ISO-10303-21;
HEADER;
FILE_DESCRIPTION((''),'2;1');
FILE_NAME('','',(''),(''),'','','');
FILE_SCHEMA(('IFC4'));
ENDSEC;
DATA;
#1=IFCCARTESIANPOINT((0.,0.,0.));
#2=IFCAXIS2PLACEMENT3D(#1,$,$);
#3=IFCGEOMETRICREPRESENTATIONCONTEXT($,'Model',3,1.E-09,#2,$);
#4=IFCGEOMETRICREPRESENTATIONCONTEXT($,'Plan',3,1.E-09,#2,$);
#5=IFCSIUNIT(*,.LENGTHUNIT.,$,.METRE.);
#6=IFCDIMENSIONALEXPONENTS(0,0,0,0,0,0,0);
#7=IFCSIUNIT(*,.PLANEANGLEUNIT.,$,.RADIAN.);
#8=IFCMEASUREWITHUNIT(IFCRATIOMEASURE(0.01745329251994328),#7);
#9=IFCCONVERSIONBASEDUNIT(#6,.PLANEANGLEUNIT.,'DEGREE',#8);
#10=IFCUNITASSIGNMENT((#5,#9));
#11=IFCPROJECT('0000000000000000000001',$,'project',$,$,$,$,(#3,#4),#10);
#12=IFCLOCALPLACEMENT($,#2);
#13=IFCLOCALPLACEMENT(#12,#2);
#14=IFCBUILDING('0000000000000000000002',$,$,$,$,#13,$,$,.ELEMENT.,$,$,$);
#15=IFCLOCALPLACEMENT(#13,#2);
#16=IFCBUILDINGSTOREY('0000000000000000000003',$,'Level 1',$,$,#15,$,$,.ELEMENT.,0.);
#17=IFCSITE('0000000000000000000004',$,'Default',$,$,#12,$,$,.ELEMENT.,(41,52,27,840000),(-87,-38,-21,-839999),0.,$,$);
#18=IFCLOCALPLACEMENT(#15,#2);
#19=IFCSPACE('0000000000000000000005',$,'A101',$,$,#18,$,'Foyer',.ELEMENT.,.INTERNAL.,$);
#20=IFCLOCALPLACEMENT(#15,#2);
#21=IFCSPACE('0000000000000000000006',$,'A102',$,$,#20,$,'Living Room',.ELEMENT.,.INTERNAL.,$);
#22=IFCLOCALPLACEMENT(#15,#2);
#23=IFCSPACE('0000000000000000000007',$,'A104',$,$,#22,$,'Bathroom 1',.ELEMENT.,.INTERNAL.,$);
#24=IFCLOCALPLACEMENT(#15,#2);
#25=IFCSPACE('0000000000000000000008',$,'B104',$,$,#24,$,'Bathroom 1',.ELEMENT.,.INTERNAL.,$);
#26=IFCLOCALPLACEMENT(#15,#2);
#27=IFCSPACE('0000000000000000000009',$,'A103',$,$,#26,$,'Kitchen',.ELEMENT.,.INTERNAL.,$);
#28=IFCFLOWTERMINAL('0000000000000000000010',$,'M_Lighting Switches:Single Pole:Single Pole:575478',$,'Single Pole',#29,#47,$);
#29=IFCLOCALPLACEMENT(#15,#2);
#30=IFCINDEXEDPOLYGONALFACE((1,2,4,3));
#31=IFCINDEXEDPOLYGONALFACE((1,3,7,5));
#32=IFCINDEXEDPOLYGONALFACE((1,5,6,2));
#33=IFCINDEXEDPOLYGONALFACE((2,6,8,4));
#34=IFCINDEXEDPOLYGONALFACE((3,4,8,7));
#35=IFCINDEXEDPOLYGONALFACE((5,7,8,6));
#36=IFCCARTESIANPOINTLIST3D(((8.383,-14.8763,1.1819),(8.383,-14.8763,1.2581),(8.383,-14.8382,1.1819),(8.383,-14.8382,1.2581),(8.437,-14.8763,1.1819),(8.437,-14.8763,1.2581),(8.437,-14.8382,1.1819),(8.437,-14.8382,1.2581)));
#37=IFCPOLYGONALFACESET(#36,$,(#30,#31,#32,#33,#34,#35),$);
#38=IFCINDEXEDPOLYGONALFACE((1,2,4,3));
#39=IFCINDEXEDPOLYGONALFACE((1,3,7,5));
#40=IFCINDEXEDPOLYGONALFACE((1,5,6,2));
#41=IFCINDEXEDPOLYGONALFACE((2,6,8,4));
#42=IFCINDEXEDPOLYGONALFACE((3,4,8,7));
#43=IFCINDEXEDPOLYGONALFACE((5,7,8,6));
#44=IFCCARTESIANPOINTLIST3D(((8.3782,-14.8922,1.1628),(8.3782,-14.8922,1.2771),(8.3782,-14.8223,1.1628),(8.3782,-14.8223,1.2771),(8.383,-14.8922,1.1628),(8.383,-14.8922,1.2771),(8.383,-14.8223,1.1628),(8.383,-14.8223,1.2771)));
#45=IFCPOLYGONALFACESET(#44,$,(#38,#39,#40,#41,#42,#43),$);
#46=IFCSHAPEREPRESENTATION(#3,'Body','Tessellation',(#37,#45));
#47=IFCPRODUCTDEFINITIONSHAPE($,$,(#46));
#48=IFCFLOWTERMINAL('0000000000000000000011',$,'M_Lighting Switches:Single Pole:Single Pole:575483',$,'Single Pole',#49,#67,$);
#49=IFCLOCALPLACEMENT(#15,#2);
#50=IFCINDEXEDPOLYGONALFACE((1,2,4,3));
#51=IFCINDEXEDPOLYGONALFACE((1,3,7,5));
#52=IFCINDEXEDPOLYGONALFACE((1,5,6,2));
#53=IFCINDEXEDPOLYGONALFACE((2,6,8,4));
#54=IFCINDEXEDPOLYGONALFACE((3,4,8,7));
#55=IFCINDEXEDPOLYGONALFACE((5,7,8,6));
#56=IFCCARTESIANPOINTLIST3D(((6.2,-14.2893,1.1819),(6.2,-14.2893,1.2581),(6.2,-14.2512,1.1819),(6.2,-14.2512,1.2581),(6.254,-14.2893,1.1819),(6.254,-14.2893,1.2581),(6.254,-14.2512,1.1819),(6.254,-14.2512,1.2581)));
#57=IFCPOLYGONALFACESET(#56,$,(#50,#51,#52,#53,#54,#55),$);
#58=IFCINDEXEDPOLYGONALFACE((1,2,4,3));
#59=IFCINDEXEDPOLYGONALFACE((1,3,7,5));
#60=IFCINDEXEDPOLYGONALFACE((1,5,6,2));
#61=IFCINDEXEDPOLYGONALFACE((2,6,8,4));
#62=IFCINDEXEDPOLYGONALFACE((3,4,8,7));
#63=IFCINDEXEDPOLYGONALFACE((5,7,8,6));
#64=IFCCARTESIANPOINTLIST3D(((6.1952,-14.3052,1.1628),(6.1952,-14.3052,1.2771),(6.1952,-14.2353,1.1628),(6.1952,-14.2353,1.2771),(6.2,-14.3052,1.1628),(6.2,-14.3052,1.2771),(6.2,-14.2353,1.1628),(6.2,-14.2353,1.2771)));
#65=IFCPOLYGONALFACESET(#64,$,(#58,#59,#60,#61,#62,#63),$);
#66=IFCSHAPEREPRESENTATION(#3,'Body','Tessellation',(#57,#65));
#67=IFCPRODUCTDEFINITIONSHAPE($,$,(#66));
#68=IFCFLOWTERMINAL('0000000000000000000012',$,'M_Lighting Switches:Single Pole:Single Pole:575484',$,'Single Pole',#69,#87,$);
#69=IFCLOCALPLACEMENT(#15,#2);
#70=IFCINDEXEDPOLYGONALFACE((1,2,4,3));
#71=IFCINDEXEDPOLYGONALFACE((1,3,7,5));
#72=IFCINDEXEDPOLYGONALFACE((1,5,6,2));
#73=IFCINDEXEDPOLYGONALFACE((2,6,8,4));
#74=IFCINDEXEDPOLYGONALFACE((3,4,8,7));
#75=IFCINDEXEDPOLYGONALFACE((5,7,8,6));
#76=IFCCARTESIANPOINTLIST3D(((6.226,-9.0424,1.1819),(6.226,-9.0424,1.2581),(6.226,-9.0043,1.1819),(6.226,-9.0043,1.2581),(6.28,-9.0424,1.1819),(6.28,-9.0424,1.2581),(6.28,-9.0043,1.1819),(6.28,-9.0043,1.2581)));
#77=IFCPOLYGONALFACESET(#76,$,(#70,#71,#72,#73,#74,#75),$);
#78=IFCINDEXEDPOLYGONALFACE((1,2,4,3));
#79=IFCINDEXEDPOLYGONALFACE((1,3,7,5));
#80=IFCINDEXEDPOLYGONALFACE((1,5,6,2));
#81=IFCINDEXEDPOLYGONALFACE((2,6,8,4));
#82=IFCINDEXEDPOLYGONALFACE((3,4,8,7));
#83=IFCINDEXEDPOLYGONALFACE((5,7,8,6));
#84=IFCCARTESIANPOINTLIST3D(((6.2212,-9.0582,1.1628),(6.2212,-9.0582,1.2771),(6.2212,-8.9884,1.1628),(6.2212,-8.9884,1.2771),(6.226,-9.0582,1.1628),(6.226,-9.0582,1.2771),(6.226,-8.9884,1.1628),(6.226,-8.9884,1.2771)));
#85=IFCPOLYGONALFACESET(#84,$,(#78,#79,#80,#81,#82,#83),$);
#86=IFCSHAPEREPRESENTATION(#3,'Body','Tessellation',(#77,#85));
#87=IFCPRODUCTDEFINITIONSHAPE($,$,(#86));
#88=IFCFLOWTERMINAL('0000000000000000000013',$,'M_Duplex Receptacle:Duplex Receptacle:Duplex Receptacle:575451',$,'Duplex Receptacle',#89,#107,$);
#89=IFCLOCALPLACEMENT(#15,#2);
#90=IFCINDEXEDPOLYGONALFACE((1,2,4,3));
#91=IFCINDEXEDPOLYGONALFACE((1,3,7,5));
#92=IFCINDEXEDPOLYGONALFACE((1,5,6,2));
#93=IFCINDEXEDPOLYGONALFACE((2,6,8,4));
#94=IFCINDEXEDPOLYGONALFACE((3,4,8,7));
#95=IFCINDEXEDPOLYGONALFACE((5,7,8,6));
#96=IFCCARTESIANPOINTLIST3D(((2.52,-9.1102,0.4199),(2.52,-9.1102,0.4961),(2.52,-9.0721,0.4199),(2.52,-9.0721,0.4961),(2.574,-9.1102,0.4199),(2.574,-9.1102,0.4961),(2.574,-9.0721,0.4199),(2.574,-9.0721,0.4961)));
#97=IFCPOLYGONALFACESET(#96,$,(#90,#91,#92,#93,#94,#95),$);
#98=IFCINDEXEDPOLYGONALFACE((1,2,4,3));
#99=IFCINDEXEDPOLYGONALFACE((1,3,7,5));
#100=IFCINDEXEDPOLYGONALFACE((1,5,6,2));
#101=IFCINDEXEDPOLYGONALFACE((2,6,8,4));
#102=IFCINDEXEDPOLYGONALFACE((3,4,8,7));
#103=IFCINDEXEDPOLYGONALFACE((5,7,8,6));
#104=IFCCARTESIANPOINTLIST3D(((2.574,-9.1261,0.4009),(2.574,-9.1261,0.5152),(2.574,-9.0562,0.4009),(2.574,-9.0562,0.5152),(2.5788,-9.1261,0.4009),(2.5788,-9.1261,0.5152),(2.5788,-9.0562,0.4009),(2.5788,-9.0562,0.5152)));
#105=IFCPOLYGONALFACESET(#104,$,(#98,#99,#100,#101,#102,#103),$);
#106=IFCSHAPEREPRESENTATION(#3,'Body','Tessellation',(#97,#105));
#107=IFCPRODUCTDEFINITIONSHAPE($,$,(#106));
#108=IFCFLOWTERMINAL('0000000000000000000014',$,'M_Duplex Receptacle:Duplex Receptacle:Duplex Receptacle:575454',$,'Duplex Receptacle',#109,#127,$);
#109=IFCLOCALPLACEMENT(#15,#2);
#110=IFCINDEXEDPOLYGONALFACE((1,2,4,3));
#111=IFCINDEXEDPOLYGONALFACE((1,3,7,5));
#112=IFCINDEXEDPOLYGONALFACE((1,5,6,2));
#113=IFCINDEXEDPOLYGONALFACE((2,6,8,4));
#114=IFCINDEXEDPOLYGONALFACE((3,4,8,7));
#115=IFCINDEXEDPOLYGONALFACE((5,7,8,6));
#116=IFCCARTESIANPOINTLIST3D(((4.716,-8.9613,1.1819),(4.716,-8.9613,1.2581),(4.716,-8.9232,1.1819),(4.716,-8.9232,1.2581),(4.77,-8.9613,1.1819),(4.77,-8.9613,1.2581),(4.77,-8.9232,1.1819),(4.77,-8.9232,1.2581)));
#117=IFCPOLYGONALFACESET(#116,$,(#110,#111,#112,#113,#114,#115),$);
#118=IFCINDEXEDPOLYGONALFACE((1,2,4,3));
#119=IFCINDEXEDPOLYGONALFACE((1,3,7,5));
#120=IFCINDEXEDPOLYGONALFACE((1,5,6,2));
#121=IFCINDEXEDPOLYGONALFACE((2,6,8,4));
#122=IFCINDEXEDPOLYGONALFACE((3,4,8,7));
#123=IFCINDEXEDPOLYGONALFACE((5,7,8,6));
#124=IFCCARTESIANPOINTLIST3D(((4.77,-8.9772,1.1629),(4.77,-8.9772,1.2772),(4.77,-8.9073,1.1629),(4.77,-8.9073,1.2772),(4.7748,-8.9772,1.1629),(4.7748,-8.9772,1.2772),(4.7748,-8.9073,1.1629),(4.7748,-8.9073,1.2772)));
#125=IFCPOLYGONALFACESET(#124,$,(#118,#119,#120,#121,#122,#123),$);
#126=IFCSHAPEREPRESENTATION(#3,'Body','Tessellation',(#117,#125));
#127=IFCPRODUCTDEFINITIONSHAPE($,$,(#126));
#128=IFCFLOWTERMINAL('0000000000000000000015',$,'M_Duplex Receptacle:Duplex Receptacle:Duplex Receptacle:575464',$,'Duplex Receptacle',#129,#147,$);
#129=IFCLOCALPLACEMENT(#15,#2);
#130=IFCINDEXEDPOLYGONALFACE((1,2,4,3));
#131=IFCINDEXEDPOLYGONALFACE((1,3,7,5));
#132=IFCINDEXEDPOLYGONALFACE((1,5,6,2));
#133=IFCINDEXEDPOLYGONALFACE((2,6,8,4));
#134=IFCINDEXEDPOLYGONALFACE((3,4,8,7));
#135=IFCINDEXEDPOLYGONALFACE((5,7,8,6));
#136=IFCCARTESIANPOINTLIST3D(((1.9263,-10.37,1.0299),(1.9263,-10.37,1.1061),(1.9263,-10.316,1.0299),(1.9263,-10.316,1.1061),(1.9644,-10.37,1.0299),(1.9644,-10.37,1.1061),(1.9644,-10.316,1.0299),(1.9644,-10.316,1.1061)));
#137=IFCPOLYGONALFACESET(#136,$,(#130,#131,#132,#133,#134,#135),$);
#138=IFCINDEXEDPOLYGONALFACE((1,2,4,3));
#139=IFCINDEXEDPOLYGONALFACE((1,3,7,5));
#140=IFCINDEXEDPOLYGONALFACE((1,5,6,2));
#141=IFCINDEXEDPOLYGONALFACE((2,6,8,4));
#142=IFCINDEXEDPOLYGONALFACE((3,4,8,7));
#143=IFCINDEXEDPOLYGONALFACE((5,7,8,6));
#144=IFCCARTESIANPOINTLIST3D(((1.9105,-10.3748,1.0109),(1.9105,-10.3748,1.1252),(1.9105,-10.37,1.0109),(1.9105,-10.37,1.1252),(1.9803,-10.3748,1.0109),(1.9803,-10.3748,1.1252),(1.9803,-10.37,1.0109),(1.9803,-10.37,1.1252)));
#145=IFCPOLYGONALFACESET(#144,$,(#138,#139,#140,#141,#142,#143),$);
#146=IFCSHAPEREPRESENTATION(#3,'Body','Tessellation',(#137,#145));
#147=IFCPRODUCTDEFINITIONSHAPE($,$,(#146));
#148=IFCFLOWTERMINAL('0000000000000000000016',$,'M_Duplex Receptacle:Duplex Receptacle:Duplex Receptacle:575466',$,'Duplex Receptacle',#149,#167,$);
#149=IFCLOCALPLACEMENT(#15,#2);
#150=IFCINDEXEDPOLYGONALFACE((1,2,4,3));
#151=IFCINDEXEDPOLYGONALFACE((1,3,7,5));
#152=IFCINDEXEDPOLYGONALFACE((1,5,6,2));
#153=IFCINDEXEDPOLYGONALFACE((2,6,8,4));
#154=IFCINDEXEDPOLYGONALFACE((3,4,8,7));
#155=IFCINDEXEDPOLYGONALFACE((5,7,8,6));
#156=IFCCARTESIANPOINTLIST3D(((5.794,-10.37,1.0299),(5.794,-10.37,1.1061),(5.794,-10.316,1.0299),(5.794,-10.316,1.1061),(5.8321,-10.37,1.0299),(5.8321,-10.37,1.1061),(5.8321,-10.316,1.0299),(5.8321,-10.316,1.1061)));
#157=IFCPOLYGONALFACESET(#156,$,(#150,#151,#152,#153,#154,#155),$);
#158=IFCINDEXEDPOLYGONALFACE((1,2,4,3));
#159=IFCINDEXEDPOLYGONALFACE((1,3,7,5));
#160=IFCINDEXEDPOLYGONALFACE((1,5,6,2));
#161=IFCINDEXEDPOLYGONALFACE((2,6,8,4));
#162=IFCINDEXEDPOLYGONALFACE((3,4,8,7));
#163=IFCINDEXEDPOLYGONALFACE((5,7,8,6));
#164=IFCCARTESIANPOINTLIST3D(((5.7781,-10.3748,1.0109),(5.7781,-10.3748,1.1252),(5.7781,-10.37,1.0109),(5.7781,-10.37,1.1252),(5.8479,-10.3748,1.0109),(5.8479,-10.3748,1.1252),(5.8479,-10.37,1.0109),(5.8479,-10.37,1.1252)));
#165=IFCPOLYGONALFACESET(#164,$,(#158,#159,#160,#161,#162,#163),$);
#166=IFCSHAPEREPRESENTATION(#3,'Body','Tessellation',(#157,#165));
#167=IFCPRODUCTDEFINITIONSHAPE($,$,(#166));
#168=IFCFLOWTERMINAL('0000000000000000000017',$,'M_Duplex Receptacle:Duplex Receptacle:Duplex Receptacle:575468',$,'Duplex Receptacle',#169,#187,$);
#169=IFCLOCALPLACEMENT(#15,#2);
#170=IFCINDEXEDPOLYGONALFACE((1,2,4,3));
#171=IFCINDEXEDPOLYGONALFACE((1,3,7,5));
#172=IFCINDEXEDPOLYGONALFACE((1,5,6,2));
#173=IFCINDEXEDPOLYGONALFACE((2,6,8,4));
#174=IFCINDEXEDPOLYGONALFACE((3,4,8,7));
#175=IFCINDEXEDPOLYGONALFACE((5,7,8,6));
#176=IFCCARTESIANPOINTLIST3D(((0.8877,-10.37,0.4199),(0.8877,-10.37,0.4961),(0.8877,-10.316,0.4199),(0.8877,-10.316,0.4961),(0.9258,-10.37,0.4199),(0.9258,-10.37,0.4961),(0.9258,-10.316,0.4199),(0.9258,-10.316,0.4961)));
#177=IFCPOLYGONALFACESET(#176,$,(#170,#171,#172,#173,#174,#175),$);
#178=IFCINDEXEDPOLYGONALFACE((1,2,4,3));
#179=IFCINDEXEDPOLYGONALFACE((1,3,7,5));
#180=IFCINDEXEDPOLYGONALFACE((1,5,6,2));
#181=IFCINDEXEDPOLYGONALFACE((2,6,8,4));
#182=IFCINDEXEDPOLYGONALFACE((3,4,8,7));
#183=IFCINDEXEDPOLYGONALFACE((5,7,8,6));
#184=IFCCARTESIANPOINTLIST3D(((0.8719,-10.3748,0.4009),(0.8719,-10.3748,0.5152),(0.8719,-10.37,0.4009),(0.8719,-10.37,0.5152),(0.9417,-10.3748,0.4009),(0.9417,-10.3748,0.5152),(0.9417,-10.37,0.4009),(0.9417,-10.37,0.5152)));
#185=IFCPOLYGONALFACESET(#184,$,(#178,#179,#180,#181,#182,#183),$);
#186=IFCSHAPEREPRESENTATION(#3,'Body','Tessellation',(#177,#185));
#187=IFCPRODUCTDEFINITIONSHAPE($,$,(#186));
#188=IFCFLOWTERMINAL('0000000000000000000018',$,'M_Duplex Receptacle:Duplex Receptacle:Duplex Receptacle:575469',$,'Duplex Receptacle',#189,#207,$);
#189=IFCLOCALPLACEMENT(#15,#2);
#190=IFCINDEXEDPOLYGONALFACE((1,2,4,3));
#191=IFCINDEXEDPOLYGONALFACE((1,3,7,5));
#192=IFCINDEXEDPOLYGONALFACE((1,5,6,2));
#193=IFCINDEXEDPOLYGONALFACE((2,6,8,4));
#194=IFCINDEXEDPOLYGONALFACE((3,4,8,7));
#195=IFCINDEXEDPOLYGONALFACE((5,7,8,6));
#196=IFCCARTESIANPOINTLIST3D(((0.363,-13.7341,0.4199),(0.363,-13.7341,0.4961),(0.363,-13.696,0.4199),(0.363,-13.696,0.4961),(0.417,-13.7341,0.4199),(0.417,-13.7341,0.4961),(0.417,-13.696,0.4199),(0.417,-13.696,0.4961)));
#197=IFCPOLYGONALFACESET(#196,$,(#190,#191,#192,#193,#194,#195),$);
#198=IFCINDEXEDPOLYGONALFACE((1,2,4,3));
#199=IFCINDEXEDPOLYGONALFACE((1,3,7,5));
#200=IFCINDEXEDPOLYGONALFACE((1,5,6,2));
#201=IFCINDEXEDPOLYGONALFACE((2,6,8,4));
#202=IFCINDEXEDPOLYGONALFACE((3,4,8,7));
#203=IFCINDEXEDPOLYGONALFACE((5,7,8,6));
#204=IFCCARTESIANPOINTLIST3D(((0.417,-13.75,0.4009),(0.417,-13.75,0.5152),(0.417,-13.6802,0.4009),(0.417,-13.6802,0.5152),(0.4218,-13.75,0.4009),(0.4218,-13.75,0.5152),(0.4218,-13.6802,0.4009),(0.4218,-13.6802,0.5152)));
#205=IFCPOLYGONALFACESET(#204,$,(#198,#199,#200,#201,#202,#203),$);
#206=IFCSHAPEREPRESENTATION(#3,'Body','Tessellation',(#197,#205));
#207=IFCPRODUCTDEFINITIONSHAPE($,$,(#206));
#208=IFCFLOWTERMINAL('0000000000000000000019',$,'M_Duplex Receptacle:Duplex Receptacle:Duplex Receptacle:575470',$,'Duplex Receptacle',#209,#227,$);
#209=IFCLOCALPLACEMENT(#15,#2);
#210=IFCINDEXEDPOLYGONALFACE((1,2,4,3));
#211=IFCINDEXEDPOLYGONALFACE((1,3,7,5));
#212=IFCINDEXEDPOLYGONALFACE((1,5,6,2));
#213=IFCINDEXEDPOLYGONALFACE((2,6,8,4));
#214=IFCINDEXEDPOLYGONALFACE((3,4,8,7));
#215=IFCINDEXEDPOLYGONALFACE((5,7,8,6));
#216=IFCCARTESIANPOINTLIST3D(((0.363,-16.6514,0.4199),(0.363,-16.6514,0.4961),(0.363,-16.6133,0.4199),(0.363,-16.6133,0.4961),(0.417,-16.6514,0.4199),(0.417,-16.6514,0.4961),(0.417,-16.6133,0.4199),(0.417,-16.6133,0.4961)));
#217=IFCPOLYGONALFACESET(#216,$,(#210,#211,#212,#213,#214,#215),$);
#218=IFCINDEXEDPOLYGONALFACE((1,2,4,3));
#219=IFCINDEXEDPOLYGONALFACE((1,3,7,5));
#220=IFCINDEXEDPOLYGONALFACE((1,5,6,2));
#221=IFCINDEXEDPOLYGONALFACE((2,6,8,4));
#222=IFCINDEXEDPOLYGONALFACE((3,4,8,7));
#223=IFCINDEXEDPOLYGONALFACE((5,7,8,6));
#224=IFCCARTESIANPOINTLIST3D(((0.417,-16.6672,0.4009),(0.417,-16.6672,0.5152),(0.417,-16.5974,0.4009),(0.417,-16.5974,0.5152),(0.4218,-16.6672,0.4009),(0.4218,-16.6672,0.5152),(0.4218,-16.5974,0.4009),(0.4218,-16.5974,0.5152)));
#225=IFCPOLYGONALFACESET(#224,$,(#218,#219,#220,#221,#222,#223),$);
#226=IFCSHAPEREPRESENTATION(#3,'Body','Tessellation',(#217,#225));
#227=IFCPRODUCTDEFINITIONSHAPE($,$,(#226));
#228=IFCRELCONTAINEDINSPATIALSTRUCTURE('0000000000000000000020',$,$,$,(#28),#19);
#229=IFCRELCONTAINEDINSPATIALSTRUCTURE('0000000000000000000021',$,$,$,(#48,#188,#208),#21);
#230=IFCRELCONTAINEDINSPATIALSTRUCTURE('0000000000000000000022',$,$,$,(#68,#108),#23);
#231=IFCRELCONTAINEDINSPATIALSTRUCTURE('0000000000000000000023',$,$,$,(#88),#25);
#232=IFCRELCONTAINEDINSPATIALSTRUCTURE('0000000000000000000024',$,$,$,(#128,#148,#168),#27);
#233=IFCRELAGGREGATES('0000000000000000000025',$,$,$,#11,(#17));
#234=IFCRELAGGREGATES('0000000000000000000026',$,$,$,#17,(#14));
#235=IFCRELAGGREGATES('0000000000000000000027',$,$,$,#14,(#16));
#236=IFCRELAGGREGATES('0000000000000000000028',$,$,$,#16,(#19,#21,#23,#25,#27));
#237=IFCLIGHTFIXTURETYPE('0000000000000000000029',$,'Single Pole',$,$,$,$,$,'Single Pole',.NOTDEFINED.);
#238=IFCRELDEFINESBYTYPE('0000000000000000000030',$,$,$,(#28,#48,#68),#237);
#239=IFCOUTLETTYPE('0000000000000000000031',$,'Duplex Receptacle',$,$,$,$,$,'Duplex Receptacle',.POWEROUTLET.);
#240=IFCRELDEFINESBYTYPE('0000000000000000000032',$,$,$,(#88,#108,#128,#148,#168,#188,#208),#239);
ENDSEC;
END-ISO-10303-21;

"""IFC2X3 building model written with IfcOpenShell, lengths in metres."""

from ifc_helpers import new_model, entity, si_unit, converted_unit, frame, origin, origin_2d_with_axis, place, context, project, spatial, rectangle, extrude, source, transform, mapped, type_object, type_shapes, element, save


model = new_model("IFC2X3")

# Units and contexts
model_context = context("Model", 3, precision=1e-09, world=origin())
plan_context = context("Plan", 3, precision=1e-09, world=origin())
ifc_project = project(units=[si_unit("LENGTHUNIT", "METRE"), converted_unit("PLANEANGLEUNIT", "DEGREE", entity("IfcRatioMeasure", 0.01745329251994328), si_unit("PLANEANGLEUNIT", "RADIAN"), dimensions=[0, 0, 0, 0, 0, 0, 0])], contexts=[model_context, plan_context])

# Site, building, storey, space
site_placement = place(None, origin())
site = spatial("IfcSite", under=ifc_project, at=site_placement, Name="Default", CompositionType="ELEMENT", RefLatitude=(41, 52, 27, 840000), RefLongitude=(-87, -38, -21, -839999), RefElevation=0.0)
building_placement = place(site_placement, origin())
building = spatial("IfcBuilding", under=site, at=building_placement, CompositionType="ELEMENT")
storey_placement = place(building_placement, origin())
storey = spatial("IfcBuildingStorey", under=building, at=storey_placement, Name="Level 1", CompositionType="ELEMENT", Elevation=0.0)
space_1_placement = place(storey_placement, origin())
space_1 = spatial("IfcSpace", under=storey, at=space_1_placement, Name="A101", LongName="Foyer", CompositionType="ELEMENT", InteriorOrExteriorSpace="INTERNAL")

# Flow terminal
light_fixture_type = type_object("IfcLightFixtureType", Name="Single Pole", ElementType="Single Pole", PredefinedType="NOTDEFINED")
shared_shape_1 = source(origin(), model_context, "Body", "SweptSolid", [
    extrude(rectangle(XDim=0.0381, YDim=0.0762, at=origin_2d_with_axis()), frame((0.0, 0.0, -0.054), z_axis=(0.0, 0.0, 1.0), x_axis=(-1.0, 0.0, 0.0)), (0.0, 0.0, 1.0), 0.054),
    extrude(rectangle(XDim=0.0698, YDim=0.1143, at=origin_2d_with_axis()), frame((0.0, 0.0, 0.0), z_axis=(0.0, 0.0, 1.0), x_axis=(-1.0, 0.0, 0.0)), (0.0, 0.0, 1.0), 0.0048),
])
type_shapes(light_fixture_type, [shared_shape_1])
flow_terminal_1_placement = place(space_1_placement, frame((8.383, -14.8573, 1.22), z_axis=(-1.0, 0.0, 0.0), x_axis=(0.0, -1.0, 0.0)))
element("IfcFlowTerminal", 1, at=flow_terminal_1_placement, inside=space_1, type_object=light_fixture_type, Name="M_Lighting Switches:Single Pole:Single Pole:575478", ObjectType="Single Pole", context=model_context, shape_type="MappedRepresentation", body=[
    mapped(shared_shape_1, transform((0.0, 0.0, 0.0), scale=1.0)),
])

# Shared definitions
space_2_placement = place(storey_placement, origin())
space_2 = spatial("IfcSpace", under=storey, at=space_2_placement, Name="A102", LongName="Living Room", CompositionType="ELEMENT", InteriorOrExteriorSpace="INTERNAL")

# Flow terminal
flow_terminal_2_placement = place(space_2_placement, frame((6.2, -14.2702, 1.22), z_axis=(-1.0, 0.0, 0.0), x_axis=(0.0, -1.0, 0.0)))
element("IfcFlowTerminal", 2, at=flow_terminal_2_placement, inside=space_2, type_object=light_fixture_type, Name="M_Lighting Switches:Single Pole:Single Pole:575483", ObjectType="Single Pole", context=model_context, shape_type="MappedRepresentation", body=[
    mapped(shared_shape_1, transform((0.0, 0.0, 0.0), scale=1.0)),
])

# Shared definitions
space_3_placement = place(storey_placement, origin())
space_3 = spatial("IfcSpace", under=storey, at=space_3_placement, Name="A104", LongName="Bathroom 1", CompositionType="ELEMENT", InteriorOrExteriorSpace="INTERNAL")

# Flow terminal
flow_terminal_3_placement = place(space_3_placement, frame((6.226, -9.0233, 1.22), z_axis=(-1.0, 0.0, 0.0), x_axis=(0.0, -1.0, 0.0)))
element("IfcFlowTerminal", 3, at=flow_terminal_3_placement, inside=space_3, type_object=light_fixture_type, Name="M_Lighting Switches:Single Pole:Single Pole:575484", ObjectType="Single Pole", context=model_context, shape_type="MappedRepresentation", body=[
    mapped(shared_shape_1, transform((0.0, 0.0, 0.0), scale=1.0)),
])

# Shared definitions
space_4_placement = place(storey_placement, origin())
space_4 = spatial("IfcSpace", under=storey, at=space_4_placement, Name="B104", LongName="Bathroom 1", CompositionType="ELEMENT", InteriorOrExteriorSpace="INTERNAL")

# Flow terminals
outlet_type = type_object("IfcOutletType", Name="Duplex Receptacle", ElementType="Duplex Receptacle", PredefinedType="POWEROUTLET")
shared_shape_2 = source(origin(), model_context, "Body", "SweptSolid", [
    extrude(rectangle(XDim=0.0381, YDim=0.0762, at=origin_2d_with_axis()), frame((0.0, 0.0, -0.054), z_axis=(0.0, 0.0, 1.0), x_axis=(-1.0, 0.0, 0.0)), (0.0, 0.0, 1.0), 0.054),
    extrude(rectangle(XDim=0.0698, YDim=0.1143, at=origin_2d_with_axis()), frame((0.0, 0.0, 0.0), z_axis=(0.0, 0.0, 1.0), x_axis=(-1.0, 0.0, 0.0)), (0.0, 0.0, 1.0), 0.0048),
])
type_shapes(outlet_type, [shared_shape_2])
flow_terminal_4_placement = place(space_4_placement, frame((2.574, -9.0912, 0.458), z_axis=(1.0, 0.0, 0.0), x_axis=(0.0, 1.0, 0.0)))
element("IfcFlowTerminal", 4, at=flow_terminal_4_placement, inside=space_4, type_object=outlet_type, Name="M_Duplex Receptacle:Duplex Receptacle:Duplex Receptacle:575451", ObjectType="Duplex Receptacle", context=model_context, shape_type="MappedRepresentation", body=[
    mapped(shared_shape_2, transform((0.0, 0.0, 0.0), scale=1.0)),
])
flow_terminal_5_placement = place(space_3_placement, frame((4.77, -8.9422, 1.22), z_axis=(1.0, 0.0, 0.0), x_axis=(0.0, 1.0, 0.0)))
element("IfcFlowTerminal", 5, at=flow_terminal_5_placement, inside=space_3, type_object=outlet_type, Name="M_Duplex Receptacle:Duplex Receptacle:Duplex Receptacle:575454", ObjectType="Duplex Receptacle", context=model_context, shape_type="MappedRepresentation", body=[
    mapped(shared_shape_2, transform((0.0, 0.0, 0.0), scale=1.0)),
])

# Shared definitions
space_5_placement = place(storey_placement, origin())
space_5 = spatial("IfcSpace", under=storey, at=space_5_placement, Name="A103", LongName="Kitchen", CompositionType="ELEMENT", InteriorOrExteriorSpace="INTERNAL")

# Flow terminals
for number, where, z_axis, x_axis, name in (
    (6, (1.9454, -10.37, 1.068), (0.0, -1.0, 0.0), (1.0, 0.0, 0.0), "M_Duplex Receptacle:Duplex Receptacle:Duplex Receptacle:575464"),
    (7, (5.813, -10.37, 1.068), (0.0, -1.0, 0.0), (1.0, 0.0, 0.0), "M_Duplex Receptacle:Duplex Receptacle:Duplex Receptacle:575466"),
    (8, (0.9068, -10.37, 0.458), (0.0, -1.0, 0.0), (1.0, 0.0, 0.0), "M_Duplex Receptacle:Duplex Receptacle:Duplex Receptacle:575468"),
):
    element("IfcFlowTerminal", number, at=place(space_5_placement, frame(where, z_axis=z_axis, x_axis=x_axis)), inside=space_5, type_object=outlet_type, Name=name, ObjectType="Duplex Receptacle", context=model_context, shape_type="MappedRepresentation", body=[
        mapped(shared_shape_2, transform((0.0, 0.0, 0.0), scale=1.0)),
    ])
for number, where, z_axis, x_axis, name in (
    (9, (0.417, -13.7151, 0.458), (1.0, 0.0, 0.0), (0.0, 1.0, 0.0), "M_Duplex Receptacle:Duplex Receptacle:Duplex Receptacle:575469"),
    (10, (0.417, -16.6323, 0.458), (1.0, 0.0, 0.0), (0.0, 1.0, 0.0), "M_Duplex Receptacle:Duplex Receptacle:Duplex Receptacle:575470"),
):
    element("IfcFlowTerminal", number, at=place(space_2_placement, frame(where, z_axis=z_axis, x_axis=x_axis)), inside=space_2, type_object=outlet_type, Name=name, ObjectType="Duplex Receptacle", context=model_context, shape_type="MappedRepresentation", body=[
        mapped(shared_shape_2, transform((0.0, 0.0, 0.0), scale=1.0)),
    ])

save(model, "model.ifc")
